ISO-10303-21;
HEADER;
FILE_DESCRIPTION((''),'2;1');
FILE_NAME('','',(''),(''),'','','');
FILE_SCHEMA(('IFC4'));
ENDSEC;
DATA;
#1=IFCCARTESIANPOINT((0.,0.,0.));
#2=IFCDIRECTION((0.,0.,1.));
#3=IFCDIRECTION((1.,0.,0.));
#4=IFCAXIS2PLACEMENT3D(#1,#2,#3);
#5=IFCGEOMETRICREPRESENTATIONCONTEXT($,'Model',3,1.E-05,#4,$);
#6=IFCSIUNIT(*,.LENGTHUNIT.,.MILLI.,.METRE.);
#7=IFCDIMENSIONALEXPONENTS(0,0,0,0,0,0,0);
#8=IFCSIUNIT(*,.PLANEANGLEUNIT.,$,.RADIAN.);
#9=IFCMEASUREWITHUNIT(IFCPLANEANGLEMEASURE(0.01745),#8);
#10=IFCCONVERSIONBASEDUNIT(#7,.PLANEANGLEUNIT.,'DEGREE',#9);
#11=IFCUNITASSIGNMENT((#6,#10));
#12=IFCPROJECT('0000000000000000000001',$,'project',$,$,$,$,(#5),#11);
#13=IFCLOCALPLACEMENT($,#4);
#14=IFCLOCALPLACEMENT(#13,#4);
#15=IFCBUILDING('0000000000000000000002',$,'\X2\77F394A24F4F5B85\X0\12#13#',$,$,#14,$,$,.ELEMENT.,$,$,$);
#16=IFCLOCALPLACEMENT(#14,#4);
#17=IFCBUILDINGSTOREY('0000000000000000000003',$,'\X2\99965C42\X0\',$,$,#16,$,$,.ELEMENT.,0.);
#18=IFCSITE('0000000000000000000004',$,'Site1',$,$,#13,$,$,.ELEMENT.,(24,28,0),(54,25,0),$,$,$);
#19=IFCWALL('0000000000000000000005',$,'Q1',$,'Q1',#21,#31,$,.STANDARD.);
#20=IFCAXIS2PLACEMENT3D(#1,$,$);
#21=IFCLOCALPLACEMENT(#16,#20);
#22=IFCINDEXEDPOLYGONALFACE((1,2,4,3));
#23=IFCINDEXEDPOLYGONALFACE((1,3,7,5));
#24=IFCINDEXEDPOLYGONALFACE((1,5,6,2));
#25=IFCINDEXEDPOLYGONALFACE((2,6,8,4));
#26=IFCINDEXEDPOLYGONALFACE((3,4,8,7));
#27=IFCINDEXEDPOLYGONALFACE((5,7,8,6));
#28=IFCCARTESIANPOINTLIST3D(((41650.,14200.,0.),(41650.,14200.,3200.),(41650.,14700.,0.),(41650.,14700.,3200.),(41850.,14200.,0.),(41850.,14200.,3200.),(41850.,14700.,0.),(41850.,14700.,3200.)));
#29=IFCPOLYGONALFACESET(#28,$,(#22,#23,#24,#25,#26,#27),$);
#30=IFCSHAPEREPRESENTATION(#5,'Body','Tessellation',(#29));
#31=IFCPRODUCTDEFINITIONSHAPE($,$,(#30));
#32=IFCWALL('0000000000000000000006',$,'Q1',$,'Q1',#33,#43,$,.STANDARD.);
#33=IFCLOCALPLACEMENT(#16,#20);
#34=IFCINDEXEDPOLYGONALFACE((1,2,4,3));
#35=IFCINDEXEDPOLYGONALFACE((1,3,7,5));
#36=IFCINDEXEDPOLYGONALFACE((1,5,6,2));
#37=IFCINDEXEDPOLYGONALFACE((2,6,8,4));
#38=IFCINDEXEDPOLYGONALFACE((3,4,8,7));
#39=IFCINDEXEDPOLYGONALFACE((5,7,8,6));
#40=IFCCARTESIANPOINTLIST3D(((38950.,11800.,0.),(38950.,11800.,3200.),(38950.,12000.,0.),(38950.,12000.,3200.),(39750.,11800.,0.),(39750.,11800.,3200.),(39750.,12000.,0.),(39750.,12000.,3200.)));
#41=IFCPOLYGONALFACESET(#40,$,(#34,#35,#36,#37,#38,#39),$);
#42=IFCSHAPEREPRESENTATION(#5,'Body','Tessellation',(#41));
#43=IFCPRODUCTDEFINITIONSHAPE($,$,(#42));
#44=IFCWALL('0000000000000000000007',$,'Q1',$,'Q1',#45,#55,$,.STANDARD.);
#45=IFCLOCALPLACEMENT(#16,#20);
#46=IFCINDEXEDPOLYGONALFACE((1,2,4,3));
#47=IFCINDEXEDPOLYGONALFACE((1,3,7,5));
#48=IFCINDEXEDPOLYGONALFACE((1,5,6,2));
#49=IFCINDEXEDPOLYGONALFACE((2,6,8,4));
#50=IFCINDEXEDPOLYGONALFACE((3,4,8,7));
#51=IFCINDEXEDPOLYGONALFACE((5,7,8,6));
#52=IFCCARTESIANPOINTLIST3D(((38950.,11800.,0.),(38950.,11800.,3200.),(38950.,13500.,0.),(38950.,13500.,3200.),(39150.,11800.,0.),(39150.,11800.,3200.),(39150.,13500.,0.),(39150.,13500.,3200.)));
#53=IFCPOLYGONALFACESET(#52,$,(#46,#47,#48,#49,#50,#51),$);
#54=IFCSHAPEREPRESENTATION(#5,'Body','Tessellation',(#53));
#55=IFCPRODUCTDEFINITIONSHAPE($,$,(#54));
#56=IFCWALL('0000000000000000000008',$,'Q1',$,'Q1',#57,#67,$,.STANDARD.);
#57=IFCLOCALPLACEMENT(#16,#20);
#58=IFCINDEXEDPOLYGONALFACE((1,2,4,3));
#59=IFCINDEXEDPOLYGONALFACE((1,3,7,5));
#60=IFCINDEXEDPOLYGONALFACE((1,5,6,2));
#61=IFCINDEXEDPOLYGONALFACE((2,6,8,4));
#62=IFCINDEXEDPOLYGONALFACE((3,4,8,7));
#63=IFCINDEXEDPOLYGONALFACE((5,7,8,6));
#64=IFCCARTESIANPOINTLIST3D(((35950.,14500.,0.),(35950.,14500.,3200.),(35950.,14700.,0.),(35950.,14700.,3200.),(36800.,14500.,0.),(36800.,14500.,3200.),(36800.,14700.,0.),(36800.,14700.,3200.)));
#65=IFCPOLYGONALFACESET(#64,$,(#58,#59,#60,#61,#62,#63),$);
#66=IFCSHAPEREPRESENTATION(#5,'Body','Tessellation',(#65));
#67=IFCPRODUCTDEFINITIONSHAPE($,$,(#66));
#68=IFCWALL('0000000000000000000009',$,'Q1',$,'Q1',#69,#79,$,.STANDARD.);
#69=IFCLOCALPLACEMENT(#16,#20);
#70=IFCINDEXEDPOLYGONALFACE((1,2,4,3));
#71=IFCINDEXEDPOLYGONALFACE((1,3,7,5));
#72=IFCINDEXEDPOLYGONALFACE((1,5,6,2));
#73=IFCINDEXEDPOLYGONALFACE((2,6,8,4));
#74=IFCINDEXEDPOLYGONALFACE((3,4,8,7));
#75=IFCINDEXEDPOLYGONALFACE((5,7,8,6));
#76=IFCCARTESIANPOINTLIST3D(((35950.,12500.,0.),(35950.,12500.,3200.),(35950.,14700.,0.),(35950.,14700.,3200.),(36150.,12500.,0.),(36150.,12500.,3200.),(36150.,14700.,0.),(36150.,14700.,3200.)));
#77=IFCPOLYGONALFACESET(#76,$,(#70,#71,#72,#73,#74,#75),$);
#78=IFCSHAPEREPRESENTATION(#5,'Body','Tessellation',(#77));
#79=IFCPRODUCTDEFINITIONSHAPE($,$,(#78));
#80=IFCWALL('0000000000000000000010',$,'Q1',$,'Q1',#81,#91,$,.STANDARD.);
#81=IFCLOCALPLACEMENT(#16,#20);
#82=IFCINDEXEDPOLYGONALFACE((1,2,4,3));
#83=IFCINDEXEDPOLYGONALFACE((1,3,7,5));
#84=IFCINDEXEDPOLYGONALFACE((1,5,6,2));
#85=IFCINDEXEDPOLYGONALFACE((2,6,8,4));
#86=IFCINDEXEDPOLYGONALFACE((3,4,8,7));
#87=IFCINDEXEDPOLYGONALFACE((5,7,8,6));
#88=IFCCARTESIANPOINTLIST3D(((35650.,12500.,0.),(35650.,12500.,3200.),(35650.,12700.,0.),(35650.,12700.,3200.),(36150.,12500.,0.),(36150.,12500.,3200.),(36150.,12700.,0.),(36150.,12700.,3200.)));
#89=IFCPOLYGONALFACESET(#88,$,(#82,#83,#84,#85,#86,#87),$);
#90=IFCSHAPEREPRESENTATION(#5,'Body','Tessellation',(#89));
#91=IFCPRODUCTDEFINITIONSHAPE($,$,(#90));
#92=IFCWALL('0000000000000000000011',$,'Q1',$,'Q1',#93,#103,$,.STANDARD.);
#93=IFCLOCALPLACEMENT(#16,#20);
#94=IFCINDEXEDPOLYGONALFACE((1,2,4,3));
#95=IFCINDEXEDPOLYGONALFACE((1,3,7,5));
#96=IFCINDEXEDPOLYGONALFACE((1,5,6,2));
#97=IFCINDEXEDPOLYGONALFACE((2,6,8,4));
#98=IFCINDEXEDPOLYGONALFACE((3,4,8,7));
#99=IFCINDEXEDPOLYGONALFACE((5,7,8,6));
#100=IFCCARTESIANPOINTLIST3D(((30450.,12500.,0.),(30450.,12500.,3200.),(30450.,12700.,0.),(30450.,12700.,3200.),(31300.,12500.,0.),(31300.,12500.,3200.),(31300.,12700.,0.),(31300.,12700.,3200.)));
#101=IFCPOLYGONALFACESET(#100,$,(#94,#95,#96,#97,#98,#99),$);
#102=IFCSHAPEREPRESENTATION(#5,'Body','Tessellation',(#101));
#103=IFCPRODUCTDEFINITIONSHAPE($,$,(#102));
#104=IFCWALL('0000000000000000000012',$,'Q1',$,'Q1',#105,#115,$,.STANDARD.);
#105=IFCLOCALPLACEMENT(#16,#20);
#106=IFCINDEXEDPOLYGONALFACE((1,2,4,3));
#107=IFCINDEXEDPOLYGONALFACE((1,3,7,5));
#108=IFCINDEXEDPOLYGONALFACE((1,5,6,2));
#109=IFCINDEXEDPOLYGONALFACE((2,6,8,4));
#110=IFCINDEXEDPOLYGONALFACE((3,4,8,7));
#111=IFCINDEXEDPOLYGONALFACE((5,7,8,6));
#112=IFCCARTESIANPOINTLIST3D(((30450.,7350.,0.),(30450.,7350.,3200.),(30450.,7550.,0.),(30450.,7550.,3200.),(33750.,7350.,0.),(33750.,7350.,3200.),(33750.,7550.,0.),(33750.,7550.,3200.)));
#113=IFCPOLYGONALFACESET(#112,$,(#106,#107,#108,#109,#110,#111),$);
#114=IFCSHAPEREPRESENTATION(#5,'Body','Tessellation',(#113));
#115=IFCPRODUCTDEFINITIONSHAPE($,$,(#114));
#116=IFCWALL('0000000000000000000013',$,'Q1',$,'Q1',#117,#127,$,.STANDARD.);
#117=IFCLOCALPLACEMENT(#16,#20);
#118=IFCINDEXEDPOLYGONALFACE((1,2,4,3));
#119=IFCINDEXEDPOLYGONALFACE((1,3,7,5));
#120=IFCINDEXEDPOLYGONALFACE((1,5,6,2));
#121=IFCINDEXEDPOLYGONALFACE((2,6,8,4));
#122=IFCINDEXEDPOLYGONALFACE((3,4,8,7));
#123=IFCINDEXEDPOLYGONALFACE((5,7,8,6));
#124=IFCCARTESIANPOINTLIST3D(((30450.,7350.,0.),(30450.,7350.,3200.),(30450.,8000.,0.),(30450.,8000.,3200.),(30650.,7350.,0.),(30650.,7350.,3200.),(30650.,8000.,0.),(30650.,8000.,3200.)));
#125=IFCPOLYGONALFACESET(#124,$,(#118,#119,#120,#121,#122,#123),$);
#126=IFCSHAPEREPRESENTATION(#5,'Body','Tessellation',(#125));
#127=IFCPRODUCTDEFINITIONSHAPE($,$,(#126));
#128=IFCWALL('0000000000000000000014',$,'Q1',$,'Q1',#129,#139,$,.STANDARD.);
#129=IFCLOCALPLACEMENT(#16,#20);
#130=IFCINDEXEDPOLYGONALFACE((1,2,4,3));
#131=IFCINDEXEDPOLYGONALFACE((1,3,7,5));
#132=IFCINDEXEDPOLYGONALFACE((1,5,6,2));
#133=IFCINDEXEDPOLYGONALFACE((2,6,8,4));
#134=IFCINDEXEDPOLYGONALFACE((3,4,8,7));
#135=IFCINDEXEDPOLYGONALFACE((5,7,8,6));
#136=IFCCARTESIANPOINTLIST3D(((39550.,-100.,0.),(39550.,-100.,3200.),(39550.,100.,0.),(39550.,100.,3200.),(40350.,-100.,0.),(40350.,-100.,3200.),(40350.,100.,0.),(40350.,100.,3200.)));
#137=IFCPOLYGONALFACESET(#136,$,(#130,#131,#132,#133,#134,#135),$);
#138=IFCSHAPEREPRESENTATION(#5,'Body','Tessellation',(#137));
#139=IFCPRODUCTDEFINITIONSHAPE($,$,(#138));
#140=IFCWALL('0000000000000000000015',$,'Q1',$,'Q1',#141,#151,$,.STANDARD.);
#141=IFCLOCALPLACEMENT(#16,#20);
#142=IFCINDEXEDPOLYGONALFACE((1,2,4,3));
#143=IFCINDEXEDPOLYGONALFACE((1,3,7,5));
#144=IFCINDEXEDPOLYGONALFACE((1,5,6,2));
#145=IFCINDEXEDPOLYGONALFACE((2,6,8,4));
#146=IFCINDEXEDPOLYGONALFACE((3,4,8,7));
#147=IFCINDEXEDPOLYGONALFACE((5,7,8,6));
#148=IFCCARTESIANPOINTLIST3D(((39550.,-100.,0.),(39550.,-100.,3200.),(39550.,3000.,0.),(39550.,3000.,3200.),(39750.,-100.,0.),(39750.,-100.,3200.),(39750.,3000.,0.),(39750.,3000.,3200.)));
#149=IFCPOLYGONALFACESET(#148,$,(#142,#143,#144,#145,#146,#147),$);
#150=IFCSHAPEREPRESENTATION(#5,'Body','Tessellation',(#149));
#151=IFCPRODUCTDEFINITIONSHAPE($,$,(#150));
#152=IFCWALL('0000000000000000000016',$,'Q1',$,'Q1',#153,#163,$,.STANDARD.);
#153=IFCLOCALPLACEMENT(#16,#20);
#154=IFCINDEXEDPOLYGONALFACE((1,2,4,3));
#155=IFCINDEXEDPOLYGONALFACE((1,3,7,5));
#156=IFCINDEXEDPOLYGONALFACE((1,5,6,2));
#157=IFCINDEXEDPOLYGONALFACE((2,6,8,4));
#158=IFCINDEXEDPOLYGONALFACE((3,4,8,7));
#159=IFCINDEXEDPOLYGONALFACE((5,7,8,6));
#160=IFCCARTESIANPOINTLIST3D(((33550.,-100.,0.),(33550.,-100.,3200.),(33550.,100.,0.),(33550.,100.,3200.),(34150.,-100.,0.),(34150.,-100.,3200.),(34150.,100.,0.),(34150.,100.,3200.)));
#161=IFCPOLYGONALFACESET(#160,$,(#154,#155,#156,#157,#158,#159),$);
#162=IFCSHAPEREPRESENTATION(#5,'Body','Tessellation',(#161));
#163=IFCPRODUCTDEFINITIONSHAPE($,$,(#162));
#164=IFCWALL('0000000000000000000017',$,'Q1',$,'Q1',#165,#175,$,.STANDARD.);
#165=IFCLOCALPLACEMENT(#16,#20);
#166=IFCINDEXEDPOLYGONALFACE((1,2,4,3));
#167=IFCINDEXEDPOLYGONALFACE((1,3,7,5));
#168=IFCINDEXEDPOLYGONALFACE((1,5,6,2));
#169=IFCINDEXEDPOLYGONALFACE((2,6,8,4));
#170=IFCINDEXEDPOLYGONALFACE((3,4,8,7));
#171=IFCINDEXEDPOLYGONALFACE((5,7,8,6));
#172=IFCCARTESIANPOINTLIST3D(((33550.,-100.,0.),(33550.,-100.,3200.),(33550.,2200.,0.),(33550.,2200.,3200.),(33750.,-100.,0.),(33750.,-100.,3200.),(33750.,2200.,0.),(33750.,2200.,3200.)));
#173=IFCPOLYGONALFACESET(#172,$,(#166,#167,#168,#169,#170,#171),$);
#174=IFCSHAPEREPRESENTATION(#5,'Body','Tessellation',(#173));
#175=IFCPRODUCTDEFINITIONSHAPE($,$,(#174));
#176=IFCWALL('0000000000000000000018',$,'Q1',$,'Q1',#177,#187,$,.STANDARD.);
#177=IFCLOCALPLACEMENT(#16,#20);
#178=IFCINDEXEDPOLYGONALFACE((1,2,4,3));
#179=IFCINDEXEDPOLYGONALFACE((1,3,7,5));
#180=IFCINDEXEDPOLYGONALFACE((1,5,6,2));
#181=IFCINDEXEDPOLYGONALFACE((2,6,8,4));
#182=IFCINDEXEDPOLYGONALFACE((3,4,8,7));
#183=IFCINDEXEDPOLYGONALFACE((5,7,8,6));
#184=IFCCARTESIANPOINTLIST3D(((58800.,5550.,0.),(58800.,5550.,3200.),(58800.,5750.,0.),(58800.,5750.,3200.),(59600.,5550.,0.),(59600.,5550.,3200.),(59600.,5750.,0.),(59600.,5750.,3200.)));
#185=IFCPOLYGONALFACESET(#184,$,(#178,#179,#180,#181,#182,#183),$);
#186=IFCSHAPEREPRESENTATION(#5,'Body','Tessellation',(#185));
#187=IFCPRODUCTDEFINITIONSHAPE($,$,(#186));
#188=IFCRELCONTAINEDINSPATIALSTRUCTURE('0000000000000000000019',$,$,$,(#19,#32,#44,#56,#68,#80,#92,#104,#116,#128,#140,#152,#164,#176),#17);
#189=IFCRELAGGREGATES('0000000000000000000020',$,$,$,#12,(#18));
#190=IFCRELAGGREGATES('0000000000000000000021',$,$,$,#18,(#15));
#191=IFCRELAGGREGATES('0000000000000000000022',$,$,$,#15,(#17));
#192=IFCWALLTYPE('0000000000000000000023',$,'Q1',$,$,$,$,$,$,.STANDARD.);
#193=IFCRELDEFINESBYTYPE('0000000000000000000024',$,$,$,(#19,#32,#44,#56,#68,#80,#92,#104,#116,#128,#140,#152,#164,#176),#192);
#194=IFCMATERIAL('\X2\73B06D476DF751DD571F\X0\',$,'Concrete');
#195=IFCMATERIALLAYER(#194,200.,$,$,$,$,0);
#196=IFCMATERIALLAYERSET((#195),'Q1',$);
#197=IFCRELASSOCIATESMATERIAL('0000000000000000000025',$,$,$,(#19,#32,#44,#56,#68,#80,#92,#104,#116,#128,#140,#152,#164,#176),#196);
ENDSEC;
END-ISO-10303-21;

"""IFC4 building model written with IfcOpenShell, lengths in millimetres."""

from ifc_helpers import new_model, entity, si_unit, converted_unit, frame, origin_with_axes, place, context, project, spatial, polyline, outline, extrude, material, layer, layer_set, type_object, element, save


model = new_model("IFC4")

# Units and contexts
model_context = context("Model", 3, precision=1e-05, world=origin_with_axes())
ifc_project = project(units=[si_unit("LENGTHUNIT", "METRE", prefix="MILLI"), converted_unit("PLANEANGLEUNIT", "DEGREE", entity("IfcPlaneAngleMeasure", 0.01745), si_unit("PLANEANGLEUNIT", "RADIAN"), dimensions=[0, 0, 0, 0, 0, 0, 0])], contexts=[model_context])

# Site, building, storey
site_placement = place(None, origin_with_axes())
site = spatial("IfcSite", under=ifc_project, at=site_placement, Name="Site1", CompositionType="ELEMENT", RefLatitude=(24, 28, 0), RefLongitude=(54, 25, 0))
building_placement = place(site_placement, origin_with_axes())
building = spatial("IfcBuilding", under=site, at=building_placement, Name="石钢住宅12#13#", CompositionType="ELEMENT")
storey_placement = place(building_placement, origin_with_axes())
storey = spatial("IfcBuildingStorey", under=building, at=storey_placement, Name="首层", CompositionType="ELEMENT", Elevation=0.0)

# Walls
ifc_material_1 = material(Name="现浇混凝土", Category="Concrete")
ifc_layer = layer(ifc_material_1, 200.0, Priority=0)
ifc_layer_set = layer_set([ifc_layer], Name="Q1")
wall_type = type_object("IfcWallType", Name="Q1", PredefinedType="STANDARD")
wall_1_placement = place(storey_placement, origin_with_axes())
element("IfcWall", 1, at=wall_1_placement, inside=storey, type_object=wall_type, material=ifc_layer_set, Name="Q1", ObjectType="Q1", PredefinedType="STANDARD", context=model_context, shape_type="SweptSolid", body=[
    extrude(outline(polyline([(0.0, 0.0), (3200.0, 0.0), (3200.0, 500.0), (0.0, 500.0), (0.0, 0.0)])), frame((41650.0, 14200.0, 3200.0), z_axis=(1.0, 0.0, 0.0), x_axis=(0.0, 0.0, -1.0)), (0.0, 0.0, 1.0), 200.0),
])
wall_2_placement = place(storey_placement, origin_with_axes())
element("IfcWall", 2, at=wall_2_placement, inside=storey, type_object=wall_type, material=ifc_layer_set, Name="Q1", ObjectType="Q1", PredefinedType="STANDARD", context=model_context, shape_type="SweptSolid", body=[
    extrude(outline(polyline([(0.0, 0.0), (3200.0, 0.0), (3200.0, 800.0), (0.0, 800.0), (0.0, 0.0)])), frame((38950.0, 12000.0, 3200.0), z_axis=(0.0, -1.0, 0.0), x_axis=(0.0, 0.0, -1.0)), (0.0, 0.0, 1.0), 200.0),
])
wall_3_placement = place(storey_placement, origin_with_axes())
element("IfcWall", 3, at=wall_3_placement, inside=storey, type_object=wall_type, material=ifc_layer_set, Name="Q1", ObjectType="Q1", PredefinedType="STANDARD", context=model_context, shape_type="SweptSolid", body=[
    extrude(outline(polyline([(0.0, 0.0), (3200.0, 0.0), (3200.0, 1700.0), (0.0, 1700.0), (0.0, 0.0)])), frame((38950.0, 11800.0, 3200.0), z_axis=(1.0, 0.0, 0.0), x_axis=(0.0, 0.0, -1.0)), (0.0, 0.0, 1.0), 200.0),
])
wall_4_placement = place(storey_placement, origin_with_axes())
element("IfcWall", 4, at=wall_4_placement, inside=storey, type_object=wall_type, material=ifc_layer_set, Name="Q1", ObjectType="Q1", PredefinedType="STANDARD", context=model_context, shape_type="SweptSolid", body=[
    extrude(outline(polyline([(0.0, 0.0), (3200.0, 0.0), (3200.0, 850.0), (0.0, 850.0), (0.0, 0.0)])), frame((35950.0, 14700.0, 3200.0), z_axis=(0.0, -1.0, 0.0), x_axis=(0.0, 0.0, -1.0)), (0.0, 0.0, 1.0), 200.0),
])
wall_5_placement = place(storey_placement, origin_with_axes())
element("IfcWall", 5, at=wall_5_placement, inside=storey, type_object=wall_type, material=ifc_layer_set, Name="Q1", ObjectType="Q1", PredefinedType="STANDARD", context=model_context, shape_type="SweptSolid", body=[
    extrude(outline(polyline([(0.0, 0.0), (3200.0, 0.0), (3200.0, 2200.0), (0.0, 2200.0), (0.0, 0.0)])), frame((35950.0, 12500.0, 3200.0), z_axis=(1.0, 0.0, 0.0), x_axis=(0.0, 0.0, -1.0)), (0.0, 0.0, 1.0), 200.0),
])
wall_6_placement = place(storey_placement, origin_with_axes())
element("IfcWall", 6, at=wall_6_placement, inside=storey, type_object=wall_type, material=ifc_layer_set, Name="Q1", ObjectType="Q1", PredefinedType="STANDARD", context=model_context, shape_type="SweptSolid", body=[
    extrude(outline(polyline([(0.0, 0.0), (3200.0, 0.0), (3200.0, 500.0), (0.0, 500.0), (0.0, 0.0)])), frame((35650.0, 12700.0, 3200.0), z_axis=(0.0, -1.0, 0.0), x_axis=(0.0, 0.0, -1.0)), (0.0, 0.0, 1.0), 200.0),
])
wall_7_placement = place(storey_placement, origin_with_axes())
element("IfcWall", 7, at=wall_7_placement, inside=storey, type_object=wall_type, material=ifc_layer_set, Name="Q1", ObjectType="Q1", PredefinedType="STANDARD", context=model_context, shape_type="SweptSolid", body=[
    extrude(outline(polyline([(0.0, 0.0), (3200.0, 0.0), (3200.0, 850.0), (0.0, 850.0), (0.0, 0.0)])), frame((30450.0, 12700.0, 3200.0), z_axis=(0.0, -1.0, 0.0), x_axis=(0.0, 0.0, -1.0)), (0.0, 0.0, 1.0), 200.0),
])
wall_8_placement = place(storey_placement, origin_with_axes())
element("IfcWall", 8, at=wall_8_placement, inside=storey, type_object=wall_type, material=ifc_layer_set, Name="Q1", ObjectType="Q1", PredefinedType="STANDARD", context=model_context, shape_type="SweptSolid", body=[
    extrude(outline(polyline([(0.0, 0.0), (3200.0, 0.0), (3200.0, 3300.0), (0.0, 3300.0), (0.0, 0.0)])), frame((30450.0, 7550.0, 3200.0), z_axis=(0.0, -1.0, 0.0), x_axis=(0.0, 0.0, -1.0)), (0.0, 0.0, 1.0), 200.0),
])
wall_9_placement = place(storey_placement, origin_with_axes())
element("IfcWall", 9, at=wall_9_placement, inside=storey, type_object=wall_type, material=ifc_layer_set, Name="Q1", ObjectType="Q1", PredefinedType="STANDARD", context=model_context, shape_type="SweptSolid", body=[
    extrude(outline(polyline([(0.0, 0.0), (3200.0, 0.0), (3200.0, 650.0), (0.0, 650.0), (0.0, 0.0)])), frame((30450.0, 7350.0, 3200.0), z_axis=(1.0, 0.0, 0.0), x_axis=(0.0, 0.0, -1.0)), (0.0, 0.0, 1.0), 200.0),
])
wall_10_placement = place(storey_placement, origin_with_axes())
element("IfcWall", 10, at=wall_10_placement, inside=storey, type_object=wall_type, material=ifc_layer_set, Name="Q1", ObjectType="Q1", PredefinedType="STANDARD", context=model_context, shape_type="SweptSolid", body=[
    extrude(outline(polyline([(0.0, 0.0), (3200.0, 0.0), (3200.0, 800.0), (0.0, 800.0), (0.0, 0.0)])), frame((39550.0, 100.0, 3200.0), z_axis=(0.0, -1.0, 0.0), x_axis=(0.0, 0.0, -1.0)), (0.0, 0.0, 1.0), 200.0),
])
wall_11_placement = place(storey_placement, origin_with_axes())
element("IfcWall", 11, at=wall_11_placement, inside=storey, type_object=wall_type, material=ifc_layer_set, Name="Q1", ObjectType="Q1", PredefinedType="STANDARD", context=model_context, shape_type="SweptSolid", body=[
    extrude(outline(polyline([(0.0, 0.0), (3200.0, 0.0), (3200.0, 3100.0), (0.0, 3100.0), (0.0, 0.0)])), frame((39550.0, -100.0, 3200.0), z_axis=(1.0, 0.0, 0.0), x_axis=(0.0, 0.0, -1.0)), (0.0, 0.0, 1.0), 200.0),
])
wall_12_placement = place(storey_placement, origin_with_axes())
element("IfcWall", 12, at=wall_12_placement, inside=storey, type_object=wall_type, material=ifc_layer_set, Name="Q1", ObjectType="Q1", PredefinedType="STANDARD", context=model_context, shape_type="SweptSolid", body=[
    extrude(outline(polyline([(0.0, 0.0), (3200.0, 0.0), (3200.0, 600.0), (0.0, 600.0), (0.0, 0.0)])), frame((33550.0, 100.0, 3200.0), z_axis=(0.0, -1.0, 0.0), x_axis=(0.0, 0.0, -1.0)), (0.0, 0.0, 1.0), 200.0),
])
wall_13_placement = place(storey_placement, origin_with_axes())
element("IfcWall", 13, at=wall_13_placement, inside=storey, type_object=wall_type, material=ifc_layer_set, Name="Q1", ObjectType="Q1", PredefinedType="STANDARD", context=model_context, shape_type="SweptSolid", body=[
    extrude(outline(polyline([(0.0, 0.0), (3200.0, 0.0), (3200.0, 2300.0), (0.0, 2300.0), (0.0, 0.0)])), frame((33550.0, -100.0, 3200.0), z_axis=(1.0, 0.0, 0.0), x_axis=(0.0, 0.0, -1.0)), (0.0, 0.0, 1.0), 200.0),
])
wall_14_placement = place(storey_placement, origin_with_axes())
element("IfcWall", 14, at=wall_14_placement, inside=storey, type_object=wall_type, material=ifc_layer_set, Name="Q1", ObjectType="Q1", PredefinedType="STANDARD", context=model_context, shape_type="SweptSolid", body=[
    extrude(outline(polyline([(0.0, 0.0), (3200.0, 0.0), (3200.0, 800.0), (0.0, 800.0), (0.0, 0.0)])), frame((58800.0, 5750.0, 3200.0), z_axis=(0.0, -1.0, 0.0), x_axis=(0.0, 0.0, -1.0)), (0.0, 0.0, 1.0), 200.0),
])

save(model, "model.ifc")
